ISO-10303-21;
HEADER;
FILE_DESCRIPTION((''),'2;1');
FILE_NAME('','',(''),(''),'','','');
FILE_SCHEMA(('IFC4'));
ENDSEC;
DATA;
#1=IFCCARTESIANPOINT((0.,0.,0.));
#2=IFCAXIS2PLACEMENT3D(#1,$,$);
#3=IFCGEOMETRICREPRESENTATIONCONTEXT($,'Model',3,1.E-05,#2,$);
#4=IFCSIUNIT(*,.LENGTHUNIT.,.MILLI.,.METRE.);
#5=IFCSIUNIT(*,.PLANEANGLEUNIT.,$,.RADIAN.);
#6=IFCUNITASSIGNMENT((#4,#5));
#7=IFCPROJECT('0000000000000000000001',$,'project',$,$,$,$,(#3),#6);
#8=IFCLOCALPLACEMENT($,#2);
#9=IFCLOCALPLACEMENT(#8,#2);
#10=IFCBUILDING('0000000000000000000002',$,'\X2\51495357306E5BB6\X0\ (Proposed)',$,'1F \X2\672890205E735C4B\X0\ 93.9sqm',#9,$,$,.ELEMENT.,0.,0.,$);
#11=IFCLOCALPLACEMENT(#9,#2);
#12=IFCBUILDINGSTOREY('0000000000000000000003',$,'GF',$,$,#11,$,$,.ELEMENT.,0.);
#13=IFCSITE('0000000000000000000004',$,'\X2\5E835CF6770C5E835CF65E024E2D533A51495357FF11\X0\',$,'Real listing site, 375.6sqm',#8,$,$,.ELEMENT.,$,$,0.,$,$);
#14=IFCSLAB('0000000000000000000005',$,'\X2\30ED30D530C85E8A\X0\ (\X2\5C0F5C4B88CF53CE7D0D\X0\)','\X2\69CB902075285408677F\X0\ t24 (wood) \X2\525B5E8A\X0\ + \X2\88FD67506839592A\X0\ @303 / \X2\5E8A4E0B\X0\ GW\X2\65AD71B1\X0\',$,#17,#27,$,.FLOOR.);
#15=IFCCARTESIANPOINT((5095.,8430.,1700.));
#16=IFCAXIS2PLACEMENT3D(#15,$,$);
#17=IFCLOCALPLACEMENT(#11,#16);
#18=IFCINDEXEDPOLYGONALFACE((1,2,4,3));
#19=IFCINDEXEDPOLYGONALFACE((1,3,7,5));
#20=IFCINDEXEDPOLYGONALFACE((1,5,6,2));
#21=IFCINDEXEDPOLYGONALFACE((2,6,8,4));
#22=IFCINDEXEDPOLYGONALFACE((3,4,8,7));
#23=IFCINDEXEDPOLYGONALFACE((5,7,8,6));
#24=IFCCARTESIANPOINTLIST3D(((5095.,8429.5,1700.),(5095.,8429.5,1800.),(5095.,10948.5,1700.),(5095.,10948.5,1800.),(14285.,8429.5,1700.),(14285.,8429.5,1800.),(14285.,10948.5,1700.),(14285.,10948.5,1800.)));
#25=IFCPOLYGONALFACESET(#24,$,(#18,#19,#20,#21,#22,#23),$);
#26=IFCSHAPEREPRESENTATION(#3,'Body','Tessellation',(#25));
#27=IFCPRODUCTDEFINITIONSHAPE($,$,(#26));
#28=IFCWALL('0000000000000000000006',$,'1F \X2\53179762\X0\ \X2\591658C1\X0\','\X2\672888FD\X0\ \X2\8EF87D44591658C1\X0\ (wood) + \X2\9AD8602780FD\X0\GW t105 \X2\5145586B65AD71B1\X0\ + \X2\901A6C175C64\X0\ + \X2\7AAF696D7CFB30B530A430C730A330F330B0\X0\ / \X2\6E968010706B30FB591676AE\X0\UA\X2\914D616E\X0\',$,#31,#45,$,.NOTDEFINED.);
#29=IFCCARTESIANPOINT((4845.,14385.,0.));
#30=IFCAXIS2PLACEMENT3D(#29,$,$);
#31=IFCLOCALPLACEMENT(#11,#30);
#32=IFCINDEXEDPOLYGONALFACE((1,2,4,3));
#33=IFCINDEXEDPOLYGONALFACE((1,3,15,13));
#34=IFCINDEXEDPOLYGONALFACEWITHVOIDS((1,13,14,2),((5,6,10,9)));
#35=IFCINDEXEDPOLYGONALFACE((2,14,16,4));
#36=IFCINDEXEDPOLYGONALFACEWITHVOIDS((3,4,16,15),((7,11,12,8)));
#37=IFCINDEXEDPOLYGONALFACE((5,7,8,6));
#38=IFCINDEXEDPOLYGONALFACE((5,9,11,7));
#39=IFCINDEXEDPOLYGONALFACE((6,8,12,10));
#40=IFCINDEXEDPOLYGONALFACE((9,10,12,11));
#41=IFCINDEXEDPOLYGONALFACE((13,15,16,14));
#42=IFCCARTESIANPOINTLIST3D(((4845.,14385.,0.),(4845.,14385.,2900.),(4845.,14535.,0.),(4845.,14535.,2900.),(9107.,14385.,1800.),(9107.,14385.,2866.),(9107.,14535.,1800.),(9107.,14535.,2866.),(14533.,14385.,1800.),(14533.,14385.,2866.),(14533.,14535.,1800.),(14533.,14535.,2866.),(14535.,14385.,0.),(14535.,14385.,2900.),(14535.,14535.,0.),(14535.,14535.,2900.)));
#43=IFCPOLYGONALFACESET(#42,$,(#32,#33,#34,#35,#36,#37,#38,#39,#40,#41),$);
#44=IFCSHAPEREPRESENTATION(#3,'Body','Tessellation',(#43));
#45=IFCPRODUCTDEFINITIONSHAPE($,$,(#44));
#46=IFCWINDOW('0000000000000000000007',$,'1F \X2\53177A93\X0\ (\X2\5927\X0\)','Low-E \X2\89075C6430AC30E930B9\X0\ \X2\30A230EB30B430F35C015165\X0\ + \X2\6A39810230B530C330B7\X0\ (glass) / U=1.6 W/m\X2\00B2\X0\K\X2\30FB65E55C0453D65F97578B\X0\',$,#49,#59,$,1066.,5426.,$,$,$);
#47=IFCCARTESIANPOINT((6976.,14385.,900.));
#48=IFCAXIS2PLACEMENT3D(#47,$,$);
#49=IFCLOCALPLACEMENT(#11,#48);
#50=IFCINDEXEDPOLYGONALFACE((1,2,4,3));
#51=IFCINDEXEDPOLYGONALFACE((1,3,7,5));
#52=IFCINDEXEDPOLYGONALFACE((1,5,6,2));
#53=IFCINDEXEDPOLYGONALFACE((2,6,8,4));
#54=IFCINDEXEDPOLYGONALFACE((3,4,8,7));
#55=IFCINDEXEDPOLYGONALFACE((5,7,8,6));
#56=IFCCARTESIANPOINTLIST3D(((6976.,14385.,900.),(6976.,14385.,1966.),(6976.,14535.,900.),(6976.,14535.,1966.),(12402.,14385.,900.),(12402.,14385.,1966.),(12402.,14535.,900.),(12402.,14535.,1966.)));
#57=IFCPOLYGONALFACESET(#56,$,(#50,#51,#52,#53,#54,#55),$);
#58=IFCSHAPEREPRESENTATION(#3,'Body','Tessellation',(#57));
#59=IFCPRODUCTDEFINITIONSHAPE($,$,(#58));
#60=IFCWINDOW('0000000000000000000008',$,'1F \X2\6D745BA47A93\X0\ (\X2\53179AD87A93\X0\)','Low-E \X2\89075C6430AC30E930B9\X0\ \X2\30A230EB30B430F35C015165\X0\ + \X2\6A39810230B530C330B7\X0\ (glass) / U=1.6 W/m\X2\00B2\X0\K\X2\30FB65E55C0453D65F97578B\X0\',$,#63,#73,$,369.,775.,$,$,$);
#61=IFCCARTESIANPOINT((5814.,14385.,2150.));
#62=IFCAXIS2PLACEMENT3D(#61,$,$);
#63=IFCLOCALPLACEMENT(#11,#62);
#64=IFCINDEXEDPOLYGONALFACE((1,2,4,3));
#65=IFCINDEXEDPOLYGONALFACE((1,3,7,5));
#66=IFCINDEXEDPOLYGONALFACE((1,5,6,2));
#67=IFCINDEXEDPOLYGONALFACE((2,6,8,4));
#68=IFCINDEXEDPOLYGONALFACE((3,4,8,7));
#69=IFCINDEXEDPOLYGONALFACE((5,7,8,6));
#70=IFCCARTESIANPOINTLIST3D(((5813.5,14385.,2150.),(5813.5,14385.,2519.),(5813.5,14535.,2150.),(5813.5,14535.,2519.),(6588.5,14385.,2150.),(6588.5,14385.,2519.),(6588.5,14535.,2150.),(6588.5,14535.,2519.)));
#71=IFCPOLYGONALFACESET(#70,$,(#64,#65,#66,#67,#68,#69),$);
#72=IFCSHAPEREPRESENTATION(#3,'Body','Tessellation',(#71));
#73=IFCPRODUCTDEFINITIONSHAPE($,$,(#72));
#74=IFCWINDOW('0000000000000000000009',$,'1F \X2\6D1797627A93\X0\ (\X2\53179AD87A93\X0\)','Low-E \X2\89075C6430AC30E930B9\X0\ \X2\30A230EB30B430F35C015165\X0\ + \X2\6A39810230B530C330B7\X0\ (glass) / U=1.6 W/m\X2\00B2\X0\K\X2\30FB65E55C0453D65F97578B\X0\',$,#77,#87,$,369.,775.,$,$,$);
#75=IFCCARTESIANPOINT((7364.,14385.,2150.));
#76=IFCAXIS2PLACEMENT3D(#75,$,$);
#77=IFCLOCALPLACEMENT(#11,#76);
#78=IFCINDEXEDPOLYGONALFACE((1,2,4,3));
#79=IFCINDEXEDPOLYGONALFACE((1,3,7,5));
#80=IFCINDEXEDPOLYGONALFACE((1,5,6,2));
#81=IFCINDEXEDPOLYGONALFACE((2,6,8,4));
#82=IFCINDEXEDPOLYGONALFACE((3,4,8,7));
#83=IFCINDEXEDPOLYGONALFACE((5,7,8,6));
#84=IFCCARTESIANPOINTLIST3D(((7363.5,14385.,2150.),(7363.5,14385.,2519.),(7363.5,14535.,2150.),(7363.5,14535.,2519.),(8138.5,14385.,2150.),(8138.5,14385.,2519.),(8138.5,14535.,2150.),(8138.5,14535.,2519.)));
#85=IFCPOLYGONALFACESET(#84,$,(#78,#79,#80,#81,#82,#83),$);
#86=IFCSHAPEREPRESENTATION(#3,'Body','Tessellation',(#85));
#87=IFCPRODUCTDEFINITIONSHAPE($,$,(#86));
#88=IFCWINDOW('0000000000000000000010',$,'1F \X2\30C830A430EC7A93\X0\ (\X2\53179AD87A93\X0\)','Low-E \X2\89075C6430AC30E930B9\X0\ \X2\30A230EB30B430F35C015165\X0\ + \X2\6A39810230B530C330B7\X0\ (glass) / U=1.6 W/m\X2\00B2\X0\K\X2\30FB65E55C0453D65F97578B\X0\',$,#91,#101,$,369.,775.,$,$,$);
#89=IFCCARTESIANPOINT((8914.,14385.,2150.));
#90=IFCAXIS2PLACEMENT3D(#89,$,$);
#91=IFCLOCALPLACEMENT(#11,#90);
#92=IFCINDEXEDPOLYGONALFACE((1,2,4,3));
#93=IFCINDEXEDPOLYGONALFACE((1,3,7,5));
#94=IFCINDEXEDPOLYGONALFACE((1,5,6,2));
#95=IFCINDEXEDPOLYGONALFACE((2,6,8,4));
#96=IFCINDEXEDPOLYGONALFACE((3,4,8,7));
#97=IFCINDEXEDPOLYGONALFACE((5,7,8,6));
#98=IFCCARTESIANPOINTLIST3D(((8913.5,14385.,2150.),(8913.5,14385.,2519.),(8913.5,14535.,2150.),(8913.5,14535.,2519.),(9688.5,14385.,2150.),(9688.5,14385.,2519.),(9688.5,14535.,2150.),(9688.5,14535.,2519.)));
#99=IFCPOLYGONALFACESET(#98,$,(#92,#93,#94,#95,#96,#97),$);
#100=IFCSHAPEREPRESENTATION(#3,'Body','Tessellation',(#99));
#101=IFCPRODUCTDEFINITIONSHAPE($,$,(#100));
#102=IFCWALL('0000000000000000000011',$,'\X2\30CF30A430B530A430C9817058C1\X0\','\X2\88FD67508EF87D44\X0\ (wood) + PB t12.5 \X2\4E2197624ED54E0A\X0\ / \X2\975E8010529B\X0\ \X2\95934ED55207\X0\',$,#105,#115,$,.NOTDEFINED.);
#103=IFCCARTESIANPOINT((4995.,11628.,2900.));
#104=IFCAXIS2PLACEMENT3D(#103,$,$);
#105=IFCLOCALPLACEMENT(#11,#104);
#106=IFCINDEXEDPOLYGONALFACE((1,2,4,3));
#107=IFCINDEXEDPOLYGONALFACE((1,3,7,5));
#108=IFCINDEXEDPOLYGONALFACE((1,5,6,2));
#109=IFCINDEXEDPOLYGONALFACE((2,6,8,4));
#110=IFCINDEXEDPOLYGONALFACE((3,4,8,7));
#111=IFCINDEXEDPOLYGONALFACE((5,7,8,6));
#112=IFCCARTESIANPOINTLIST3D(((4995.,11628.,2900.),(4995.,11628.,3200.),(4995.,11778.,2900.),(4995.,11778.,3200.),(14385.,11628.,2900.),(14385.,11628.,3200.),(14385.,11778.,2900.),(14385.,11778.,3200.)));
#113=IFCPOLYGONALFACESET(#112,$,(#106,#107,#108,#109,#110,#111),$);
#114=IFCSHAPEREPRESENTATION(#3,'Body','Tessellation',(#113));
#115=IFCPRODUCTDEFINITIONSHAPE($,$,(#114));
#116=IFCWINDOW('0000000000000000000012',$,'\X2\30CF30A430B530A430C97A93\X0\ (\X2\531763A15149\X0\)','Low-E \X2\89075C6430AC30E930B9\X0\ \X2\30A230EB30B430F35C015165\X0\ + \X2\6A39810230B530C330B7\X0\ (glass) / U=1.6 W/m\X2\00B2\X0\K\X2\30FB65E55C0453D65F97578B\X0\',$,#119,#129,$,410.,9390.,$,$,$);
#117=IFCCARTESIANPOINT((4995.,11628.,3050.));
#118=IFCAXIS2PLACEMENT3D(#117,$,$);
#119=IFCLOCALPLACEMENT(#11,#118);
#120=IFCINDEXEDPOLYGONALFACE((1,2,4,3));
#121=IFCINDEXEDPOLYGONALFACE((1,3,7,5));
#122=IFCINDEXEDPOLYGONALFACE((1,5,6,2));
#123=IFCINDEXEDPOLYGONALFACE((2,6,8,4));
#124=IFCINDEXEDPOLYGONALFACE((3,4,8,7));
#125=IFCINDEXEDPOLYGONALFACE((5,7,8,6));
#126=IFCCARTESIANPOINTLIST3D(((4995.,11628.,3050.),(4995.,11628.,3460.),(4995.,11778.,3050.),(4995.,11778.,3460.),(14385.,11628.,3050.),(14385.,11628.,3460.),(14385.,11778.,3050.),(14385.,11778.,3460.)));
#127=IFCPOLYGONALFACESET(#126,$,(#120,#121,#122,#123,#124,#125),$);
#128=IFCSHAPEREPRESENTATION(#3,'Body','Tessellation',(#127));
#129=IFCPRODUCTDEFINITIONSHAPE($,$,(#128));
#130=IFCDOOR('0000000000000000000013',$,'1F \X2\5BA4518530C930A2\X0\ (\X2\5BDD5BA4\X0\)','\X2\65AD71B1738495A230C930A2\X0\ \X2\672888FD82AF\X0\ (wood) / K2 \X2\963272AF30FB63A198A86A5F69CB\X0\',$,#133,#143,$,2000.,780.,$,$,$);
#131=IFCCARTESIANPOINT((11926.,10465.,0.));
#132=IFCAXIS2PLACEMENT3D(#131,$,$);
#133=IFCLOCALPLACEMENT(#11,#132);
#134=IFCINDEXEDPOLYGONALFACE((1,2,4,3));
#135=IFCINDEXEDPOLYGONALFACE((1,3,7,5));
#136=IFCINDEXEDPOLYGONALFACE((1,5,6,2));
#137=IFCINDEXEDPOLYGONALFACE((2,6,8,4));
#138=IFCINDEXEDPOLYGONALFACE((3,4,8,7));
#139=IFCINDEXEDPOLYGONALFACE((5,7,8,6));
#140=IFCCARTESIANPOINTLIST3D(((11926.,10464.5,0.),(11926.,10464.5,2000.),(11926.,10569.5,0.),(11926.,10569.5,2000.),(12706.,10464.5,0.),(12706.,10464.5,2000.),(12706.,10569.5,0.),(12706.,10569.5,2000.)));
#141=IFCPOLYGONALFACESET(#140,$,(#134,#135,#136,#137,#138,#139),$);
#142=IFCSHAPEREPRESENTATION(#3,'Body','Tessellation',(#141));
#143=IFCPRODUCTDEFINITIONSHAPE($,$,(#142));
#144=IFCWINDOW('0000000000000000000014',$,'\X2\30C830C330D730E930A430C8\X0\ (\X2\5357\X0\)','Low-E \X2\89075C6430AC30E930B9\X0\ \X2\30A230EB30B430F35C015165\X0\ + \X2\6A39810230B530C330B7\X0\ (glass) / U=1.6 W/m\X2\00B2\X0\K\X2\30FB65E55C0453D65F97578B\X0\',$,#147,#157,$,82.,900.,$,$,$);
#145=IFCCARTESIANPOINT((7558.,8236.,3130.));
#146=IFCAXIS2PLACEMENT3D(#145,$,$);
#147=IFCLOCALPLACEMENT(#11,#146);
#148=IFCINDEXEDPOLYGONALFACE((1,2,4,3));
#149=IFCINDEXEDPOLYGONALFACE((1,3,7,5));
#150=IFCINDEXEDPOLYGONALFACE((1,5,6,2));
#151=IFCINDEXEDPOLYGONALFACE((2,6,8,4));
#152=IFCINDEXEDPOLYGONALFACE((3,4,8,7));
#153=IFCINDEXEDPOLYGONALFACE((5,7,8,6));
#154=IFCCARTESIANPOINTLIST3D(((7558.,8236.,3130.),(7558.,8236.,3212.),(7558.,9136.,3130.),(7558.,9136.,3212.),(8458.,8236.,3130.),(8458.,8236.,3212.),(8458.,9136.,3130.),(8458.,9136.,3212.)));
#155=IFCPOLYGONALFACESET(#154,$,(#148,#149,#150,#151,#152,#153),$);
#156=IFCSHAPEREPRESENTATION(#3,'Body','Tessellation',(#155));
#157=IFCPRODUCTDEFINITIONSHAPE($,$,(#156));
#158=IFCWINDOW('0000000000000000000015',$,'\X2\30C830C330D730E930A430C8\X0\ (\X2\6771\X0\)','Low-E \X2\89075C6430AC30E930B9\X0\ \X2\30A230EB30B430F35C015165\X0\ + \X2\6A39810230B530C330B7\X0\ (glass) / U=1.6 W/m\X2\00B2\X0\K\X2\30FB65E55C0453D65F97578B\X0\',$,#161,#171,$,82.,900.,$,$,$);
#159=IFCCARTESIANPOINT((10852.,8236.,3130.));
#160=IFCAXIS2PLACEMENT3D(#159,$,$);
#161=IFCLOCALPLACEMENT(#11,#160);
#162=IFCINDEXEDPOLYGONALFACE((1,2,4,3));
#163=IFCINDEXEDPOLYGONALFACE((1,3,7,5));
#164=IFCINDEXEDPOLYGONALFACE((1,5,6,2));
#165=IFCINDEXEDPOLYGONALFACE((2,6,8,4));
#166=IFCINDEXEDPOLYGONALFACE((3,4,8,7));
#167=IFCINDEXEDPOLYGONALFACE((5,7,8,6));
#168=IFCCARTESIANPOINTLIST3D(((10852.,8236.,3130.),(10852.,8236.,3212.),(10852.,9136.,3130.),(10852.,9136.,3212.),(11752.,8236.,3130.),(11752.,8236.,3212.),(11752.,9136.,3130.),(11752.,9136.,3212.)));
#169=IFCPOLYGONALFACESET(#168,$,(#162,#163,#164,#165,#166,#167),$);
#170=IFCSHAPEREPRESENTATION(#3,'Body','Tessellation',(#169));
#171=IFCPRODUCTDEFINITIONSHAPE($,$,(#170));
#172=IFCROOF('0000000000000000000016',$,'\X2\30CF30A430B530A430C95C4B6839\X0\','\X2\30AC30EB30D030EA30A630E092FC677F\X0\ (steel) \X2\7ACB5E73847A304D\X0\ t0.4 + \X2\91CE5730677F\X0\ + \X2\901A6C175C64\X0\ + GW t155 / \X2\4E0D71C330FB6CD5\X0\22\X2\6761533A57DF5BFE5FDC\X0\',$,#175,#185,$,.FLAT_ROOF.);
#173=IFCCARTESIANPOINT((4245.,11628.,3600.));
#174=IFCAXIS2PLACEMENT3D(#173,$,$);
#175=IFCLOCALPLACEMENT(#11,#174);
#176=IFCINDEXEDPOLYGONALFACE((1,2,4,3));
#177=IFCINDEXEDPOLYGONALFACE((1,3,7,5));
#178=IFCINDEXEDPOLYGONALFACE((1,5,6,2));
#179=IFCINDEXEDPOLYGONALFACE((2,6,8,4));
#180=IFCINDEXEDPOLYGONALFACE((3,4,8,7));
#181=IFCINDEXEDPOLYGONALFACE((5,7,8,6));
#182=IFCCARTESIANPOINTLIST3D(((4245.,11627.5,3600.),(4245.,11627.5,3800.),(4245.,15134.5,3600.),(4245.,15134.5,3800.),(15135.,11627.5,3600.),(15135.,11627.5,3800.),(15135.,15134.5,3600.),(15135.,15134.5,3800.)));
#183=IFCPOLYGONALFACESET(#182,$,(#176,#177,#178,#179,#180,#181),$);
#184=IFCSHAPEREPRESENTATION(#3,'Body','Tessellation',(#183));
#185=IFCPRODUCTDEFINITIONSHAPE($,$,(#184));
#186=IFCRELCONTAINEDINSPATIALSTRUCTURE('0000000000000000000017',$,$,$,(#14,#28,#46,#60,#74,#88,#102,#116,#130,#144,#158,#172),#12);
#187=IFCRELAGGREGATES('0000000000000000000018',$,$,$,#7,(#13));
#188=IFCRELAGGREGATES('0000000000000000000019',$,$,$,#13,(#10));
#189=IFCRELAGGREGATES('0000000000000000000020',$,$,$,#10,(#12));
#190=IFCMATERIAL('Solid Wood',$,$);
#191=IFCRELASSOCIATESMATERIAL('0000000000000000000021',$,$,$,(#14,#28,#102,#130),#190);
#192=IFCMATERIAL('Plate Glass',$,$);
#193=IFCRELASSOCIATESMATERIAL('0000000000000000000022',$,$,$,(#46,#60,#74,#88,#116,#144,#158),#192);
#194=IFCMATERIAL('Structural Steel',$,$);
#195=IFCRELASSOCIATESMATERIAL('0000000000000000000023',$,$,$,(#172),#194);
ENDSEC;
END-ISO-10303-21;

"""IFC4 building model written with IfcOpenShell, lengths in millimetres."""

from ifc_helpers import new_model, si_unit, frame, frame_2d, origin, place, context, project, spatial, rectangle, extrude, material, element, fill, save


model = new_model("IFC4")

# Units and contexts
model_context = context("Model", 3, precision=1e-05, world=origin())
ifc_project = project(units=[si_unit("LENGTHUNIT", "METRE", prefix="MILLI"), si_unit("PLANEANGLEUNIT", "RADIAN")], contexts=[model_context])

# Site, building, storey
site_placement = place(None, origin())
site = spatial("IfcSite", under=ifc_project, at=site_placement, Name="広島県広島市中区光南１", ObjectType="Real listing site, 375.6sqm", CompositionType="ELEMENT", RefElevation=0.0)
building_placement = place(site_placement, origin())
building = spatial("IfcBuilding", under=site, at=building_placement, Name="光南の家 (Proposed)", ObjectType="1F 木造平屋 93.9sqm", CompositionType="ELEMENT", ElevationOfRefHeight=0.0, ElevationOfTerrain=0.0)
storey_placement = place(building_placement, origin())
storey = spatial("IfcBuildingStorey", under=building, at=storey_placement, Name="GF", CompositionType="ELEMENT", Elevation=0.0)

# Slab
ifc_material_1 = material(Name="Solid Wood")
slab_placement = place(storey_placement, frame((5095.0, 8430.0, 1700.0)))
element("IfcSlab", 1, at=slab_placement, inside=storey, material=ifc_material_1, Name="ロフト床 (小屋裏収納)", Description="構造用合板 t24 (wood) 剛床 + 製材根太 @303 / 床下 GW断熱", PredefinedType="FLOOR", context=model_context, shape_type="SweptSolid", body=[
    extrude(rectangle(XDim=9190.0, YDim=2519.0, at=frame_2d((4595.0, 1259.0))), frame((5095.0, 8430.0, 1700.0)), (0.0, 0.0, 1.0), 100.0),
])

# Wall, openings, windows
wall_1_placement = place(storey_placement, frame((4845.0, 14385.0, 0.0)))
wall_1 = element("IfcWall", 2, at=wall_1_placement, inside=storey, material=ifc_material_1, Name="1F 北面 外壁", Description="木製 軸組外壁 (wood) + 高性能GW t105 充填断熱 + 通気層 + 窯業系サイディング / 準耐火・外皮UA配慮", PredefinedType="NOTDEFINED", context=model_context, shape_type="SweptSolid", body=[
    extrude(rectangle(XDim=9690.0, YDim=150.0, at=frame_2d((4845.0, 75.0))), frame((4845.0, 14385.0, 0.0)), (0.0, 0.0, 1.0), 2900.0),
])
opening_1_placement = place(storey_placement, frame((6976.0, 14385.0, 900.0)))
opening_1 = element("IfcOpeningElement", 3, at=opening_1_placement, cuts=wall_1, PredefinedType="NOTDEFINED", context=model_context, shape_type="SweptSolid", body=[
    extrude(rectangle(XDim=5426.0, YDim=150.0, at=frame_2d((2713.0, 75.0))), frame((6976.0, 14385.0, 900.0)), (0.0, 0.0, 1.0), 1066.0),
])
opening_2_placement = place(storey_placement, frame((5814.0, 14385.0, 2150.0)))
opening_2 = element("IfcOpeningElement", 4, at=opening_2_placement, cuts=wall_1, PredefinedType="NOTDEFINED", context=model_context, shape_type="SweptSolid", body=[
    extrude(rectangle(XDim=775.0, YDim=150.0, at=frame_2d((387.0, 75.0))), frame((5814.0, 14385.0, 2150.0)), (0.0, 0.0, 1.0), 369.0),
])
opening_3_placement = place(storey_placement, frame((7364.0, 14385.0, 2150.0)))
opening_3 = element("IfcOpeningElement", 5, at=opening_3_placement, cuts=wall_1, PredefinedType="NOTDEFINED", context=model_context, shape_type="SweptSolid", body=[
    extrude(rectangle(XDim=775.0, YDim=150.0, at=frame_2d((387.0, 75.0))), frame((7364.0, 14385.0, 2150.0)), (0.0, 0.0, 1.0), 369.0),
])
opening_4_placement = place(storey_placement, frame((8914.0, 14385.0, 2150.0)))
opening_4 = element("IfcOpeningElement", 6, at=opening_4_placement, cuts=wall_1, PredefinedType="NOTDEFINED", context=model_context, shape_type="SweptSolid", body=[
    extrude(rectangle(XDim=775.0, YDim=150.0, at=frame_2d((387.0, 75.0))), frame((8914.0, 14385.0, 2150.0)), (0.0, 0.0, 1.0), 369.0),
])
ifc_material_2 = material(Name="Plate Glass")
window_1_placement = place(storey_placement, frame((6976.0, 14385.0, 900.0)))
window_1 = element("IfcWindow", 7, at=window_1_placement, inside=storey, material=ifc_material_2, Name="1F 北窓 (大)", Description="Low-E 複層ガラス アルゴン封入 + 樹脂サッシ (glass) / U=1.6 W/m²K・日射取得型", OverallHeight=1066.0, OverallWidth=5426.0, context=model_context, shape_type="SweptSolid", body=[
    extrude(rectangle(XDim=5426.0, YDim=150.0, at=frame_2d((2713.0, 75.0))), frame((6976.0, 14385.0, 900.0)), (0.0, 0.0, 1.0), 1066.0),
])
fill(opening_1, window_1)
window_2_placement = place(storey_placement, frame((5814.0, 14385.0, 2150.0)))
window_2 = element("IfcWindow", 8, at=window_2_placement, inside=storey, material=ifc_material_2, Name="1F 浴室窓 (北高窓)", Description="Low-E 複層ガラス アルゴン封入 + 樹脂サッシ (glass) / U=1.6 W/m²K・日射取得型", OverallHeight=369.0, OverallWidth=775.0, context=model_context, shape_type="SweptSolid", body=[
    extrude(rectangle(XDim=775.0, YDim=150.0, at=frame_2d((387.0, 75.0))), frame((5814.0, 14385.0, 2150.0)), (0.0, 0.0, 1.0), 369.0),
])
fill(opening_2, window_2)
window_3_placement = place(storey_placement, frame((7364.0, 14385.0, 2150.0)))
window_3 = element("IfcWindow", 9, at=window_3_placement, inside=storey, material=ifc_material_2, Name="1F 洗面窓 (北高窓)", Description="Low-E 複層ガラス アルゴン封入 + 樹脂サッシ (glass) / U=1.6 W/m²K・日射取得型", OverallHeight=369.0, OverallWidth=775.0, context=model_context, shape_type="SweptSolid", body=[
    extrude(rectangle(XDim=775.0, YDim=150.0, at=frame_2d((387.0, 75.0))), frame((7364.0, 14385.0, 2150.0)), (0.0, 0.0, 1.0), 369.0),
])
fill(opening_3, window_3)
window_4_placement = place(storey_placement, frame((8914.0, 14385.0, 2150.0)))
window_4 = element("IfcWindow", 10, at=window_4_placement, inside=storey, material=ifc_material_2, Name="1F トイレ窓 (北高窓)", Description="Low-E 複層ガラス アルゴン封入 + 樹脂サッシ (glass) / U=1.6 W/m²K・日射取得型", OverallHeight=369.0, OverallWidth=775.0, context=model_context, shape_type="SweptSolid", body=[
    extrude(rectangle(XDim=775.0, YDim=150.0, at=frame_2d((387.0, 75.0))), frame((8914.0, 14385.0, 2150.0)), (0.0, 0.0, 1.0), 369.0),
])
fill(opening_4, window_4)

# Wall, opening, window
wall_2_placement = place(storey_placement, frame((4995.0, 11628.0, 2900.0)))
wall_2 = element("IfcWall", 11, at=wall_2_placement, inside=storey, material=ifc_material_1, Name="ハイサイド腰壁", Description="製材軸組 (wood) + PB t12.5 両面仕上 / 非耐力 間仕切", PredefinedType="NOTDEFINED", context=model_context, shape_type="SweptSolid", body=[
    extrude(rectangle(XDim=9390.0, YDim=150.0, at=frame_2d((4695.0, 75.0))), frame((4995.0, 11628.0, 2900.0)), (0.0, 0.0, 1.0), 700.0),
])
opening_5_placement = place(storey_placement, frame((4995.0, 11628.0, 3050.0)))
opening_5 = element("IfcOpeningElement", 12, at=opening_5_placement, cuts=wall_2, PredefinedType="NOTDEFINED", context=model_context, shape_type="SweptSolid", body=[
    extrude(rectangle(XDim=9390.0, YDim=150.0, at=frame_2d((4695.0, 75.0))), frame((4995.0, 11628.0, 3050.0)), (0.0, 0.0, 1.0), 410.0),
])
window_5_placement = place(storey_placement, frame((4995.0, 11628.0, 3050.0)))
window_5 = element("IfcWindow", 13, at=window_5_placement, inside=storey, material=ifc_material_2, Name="ハイサイド窓 (北採光)", Description="Low-E 複層ガラス アルゴン封入 + 樹脂サッシ (glass) / U=1.6 W/m²K・日射取得型", OverallHeight=410.0, OverallWidth=9390.0, context=model_context, shape_type="SweptSolid", body=[
    extrude(rectangle(XDim=9390.0, YDim=150.0, at=frame_2d((4695.0, 75.0))), frame((4995.0, 11628.0, 3050.0)), (0.0, 0.0, 1.0), 410.0),
])
fill(opening_5, window_5)

# Door
door_1_placement = place(storey_placement, frame((11926.0, 10465.0, 0.0)))
element("IfcDoor", 14, at=door_1_placement, inside=storey, material=ifc_material_1, Name="1F 室内ドア (寝室)", Description="断熱玄関ドア 木製芯 (wood) / K2 防犯・採風機構", OverallHeight=2000.0, OverallWidth=780.0, context=model_context, shape_type="SweptSolid", body=[
    extrude(rectangle(XDim=780.0, YDim=105.0, at=frame_2d((390.0, 52.0))), frame((11926.0, 10465.0, 0.0)), (0.0, 0.0, 1.0), 2000.0),
])

# Windows
window_6_placement = place(storey_placement, frame((7558.0, 8236.0, 3130.0)))
element("IfcWindow", 15, at=window_6_placement, inside=storey, material=ifc_material_2, Name="トップライト (南)", Description="Low-E 複層ガラス アルゴン封入 + 樹脂サッシ (glass) / U=1.6 W/m²K・日射取得型", OverallHeight=82.0, OverallWidth=900.0, context=model_context, shape_type="SweptSolid", body=[
    extrude(rectangle(XDim=900.0, YDim=900.0, at=frame_2d((450.0, 450.0))), frame((7558.0, 8236.0, 3130.0)), (0.0, 0.0, 1.0), 82.0),
])
window_7_placement = place(storey_placement, frame((10852.0, 8236.0, 3130.0)))
element("IfcWindow", 16, at=window_7_placement, inside=storey, material=ifc_material_2, Name="トップライト (東)", Description="Low-E 複層ガラス アルゴン封入 + 樹脂サッシ (glass) / U=1.6 W/m²K・日射取得型", OverallHeight=82.0, OverallWidth=900.0, context=model_context, shape_type="SweptSolid", body=[
    extrude(rectangle(XDim=900.0, YDim=900.0, at=frame_2d((450.0, 450.0))), frame((10852.0, 8236.0, 3130.0)), (0.0, 0.0, 1.0), 82.0),
])

# Roof
ifc_material_3 = material(Name="Structural Steel")
roof_placement = place(storey_placement, frame((4245.0, 11628.0, 3600.0)))
element("IfcRoof", 17, at=roof_placement, inside=storey, material=ifc_material_3, Name="ハイサイド屋根", Description="ガルバリウム鋼板 (steel) 立平葺き t0.4 + 野地板 + 通気層 + GW t155 / 不燃・法22条区域対応", PredefinedType="FLAT_ROOF", context=model_context, shape_type="SweptSolid", body=[
    extrude(rectangle(XDim=10890.0, YDim=3507.0, at=frame_2d((5445.0, 1753.0))), frame((4245.0, 11628.0, 3600.0)), (0.0, 0.0, 1.0), 200.0),
])

save(model, "model.ifc")
